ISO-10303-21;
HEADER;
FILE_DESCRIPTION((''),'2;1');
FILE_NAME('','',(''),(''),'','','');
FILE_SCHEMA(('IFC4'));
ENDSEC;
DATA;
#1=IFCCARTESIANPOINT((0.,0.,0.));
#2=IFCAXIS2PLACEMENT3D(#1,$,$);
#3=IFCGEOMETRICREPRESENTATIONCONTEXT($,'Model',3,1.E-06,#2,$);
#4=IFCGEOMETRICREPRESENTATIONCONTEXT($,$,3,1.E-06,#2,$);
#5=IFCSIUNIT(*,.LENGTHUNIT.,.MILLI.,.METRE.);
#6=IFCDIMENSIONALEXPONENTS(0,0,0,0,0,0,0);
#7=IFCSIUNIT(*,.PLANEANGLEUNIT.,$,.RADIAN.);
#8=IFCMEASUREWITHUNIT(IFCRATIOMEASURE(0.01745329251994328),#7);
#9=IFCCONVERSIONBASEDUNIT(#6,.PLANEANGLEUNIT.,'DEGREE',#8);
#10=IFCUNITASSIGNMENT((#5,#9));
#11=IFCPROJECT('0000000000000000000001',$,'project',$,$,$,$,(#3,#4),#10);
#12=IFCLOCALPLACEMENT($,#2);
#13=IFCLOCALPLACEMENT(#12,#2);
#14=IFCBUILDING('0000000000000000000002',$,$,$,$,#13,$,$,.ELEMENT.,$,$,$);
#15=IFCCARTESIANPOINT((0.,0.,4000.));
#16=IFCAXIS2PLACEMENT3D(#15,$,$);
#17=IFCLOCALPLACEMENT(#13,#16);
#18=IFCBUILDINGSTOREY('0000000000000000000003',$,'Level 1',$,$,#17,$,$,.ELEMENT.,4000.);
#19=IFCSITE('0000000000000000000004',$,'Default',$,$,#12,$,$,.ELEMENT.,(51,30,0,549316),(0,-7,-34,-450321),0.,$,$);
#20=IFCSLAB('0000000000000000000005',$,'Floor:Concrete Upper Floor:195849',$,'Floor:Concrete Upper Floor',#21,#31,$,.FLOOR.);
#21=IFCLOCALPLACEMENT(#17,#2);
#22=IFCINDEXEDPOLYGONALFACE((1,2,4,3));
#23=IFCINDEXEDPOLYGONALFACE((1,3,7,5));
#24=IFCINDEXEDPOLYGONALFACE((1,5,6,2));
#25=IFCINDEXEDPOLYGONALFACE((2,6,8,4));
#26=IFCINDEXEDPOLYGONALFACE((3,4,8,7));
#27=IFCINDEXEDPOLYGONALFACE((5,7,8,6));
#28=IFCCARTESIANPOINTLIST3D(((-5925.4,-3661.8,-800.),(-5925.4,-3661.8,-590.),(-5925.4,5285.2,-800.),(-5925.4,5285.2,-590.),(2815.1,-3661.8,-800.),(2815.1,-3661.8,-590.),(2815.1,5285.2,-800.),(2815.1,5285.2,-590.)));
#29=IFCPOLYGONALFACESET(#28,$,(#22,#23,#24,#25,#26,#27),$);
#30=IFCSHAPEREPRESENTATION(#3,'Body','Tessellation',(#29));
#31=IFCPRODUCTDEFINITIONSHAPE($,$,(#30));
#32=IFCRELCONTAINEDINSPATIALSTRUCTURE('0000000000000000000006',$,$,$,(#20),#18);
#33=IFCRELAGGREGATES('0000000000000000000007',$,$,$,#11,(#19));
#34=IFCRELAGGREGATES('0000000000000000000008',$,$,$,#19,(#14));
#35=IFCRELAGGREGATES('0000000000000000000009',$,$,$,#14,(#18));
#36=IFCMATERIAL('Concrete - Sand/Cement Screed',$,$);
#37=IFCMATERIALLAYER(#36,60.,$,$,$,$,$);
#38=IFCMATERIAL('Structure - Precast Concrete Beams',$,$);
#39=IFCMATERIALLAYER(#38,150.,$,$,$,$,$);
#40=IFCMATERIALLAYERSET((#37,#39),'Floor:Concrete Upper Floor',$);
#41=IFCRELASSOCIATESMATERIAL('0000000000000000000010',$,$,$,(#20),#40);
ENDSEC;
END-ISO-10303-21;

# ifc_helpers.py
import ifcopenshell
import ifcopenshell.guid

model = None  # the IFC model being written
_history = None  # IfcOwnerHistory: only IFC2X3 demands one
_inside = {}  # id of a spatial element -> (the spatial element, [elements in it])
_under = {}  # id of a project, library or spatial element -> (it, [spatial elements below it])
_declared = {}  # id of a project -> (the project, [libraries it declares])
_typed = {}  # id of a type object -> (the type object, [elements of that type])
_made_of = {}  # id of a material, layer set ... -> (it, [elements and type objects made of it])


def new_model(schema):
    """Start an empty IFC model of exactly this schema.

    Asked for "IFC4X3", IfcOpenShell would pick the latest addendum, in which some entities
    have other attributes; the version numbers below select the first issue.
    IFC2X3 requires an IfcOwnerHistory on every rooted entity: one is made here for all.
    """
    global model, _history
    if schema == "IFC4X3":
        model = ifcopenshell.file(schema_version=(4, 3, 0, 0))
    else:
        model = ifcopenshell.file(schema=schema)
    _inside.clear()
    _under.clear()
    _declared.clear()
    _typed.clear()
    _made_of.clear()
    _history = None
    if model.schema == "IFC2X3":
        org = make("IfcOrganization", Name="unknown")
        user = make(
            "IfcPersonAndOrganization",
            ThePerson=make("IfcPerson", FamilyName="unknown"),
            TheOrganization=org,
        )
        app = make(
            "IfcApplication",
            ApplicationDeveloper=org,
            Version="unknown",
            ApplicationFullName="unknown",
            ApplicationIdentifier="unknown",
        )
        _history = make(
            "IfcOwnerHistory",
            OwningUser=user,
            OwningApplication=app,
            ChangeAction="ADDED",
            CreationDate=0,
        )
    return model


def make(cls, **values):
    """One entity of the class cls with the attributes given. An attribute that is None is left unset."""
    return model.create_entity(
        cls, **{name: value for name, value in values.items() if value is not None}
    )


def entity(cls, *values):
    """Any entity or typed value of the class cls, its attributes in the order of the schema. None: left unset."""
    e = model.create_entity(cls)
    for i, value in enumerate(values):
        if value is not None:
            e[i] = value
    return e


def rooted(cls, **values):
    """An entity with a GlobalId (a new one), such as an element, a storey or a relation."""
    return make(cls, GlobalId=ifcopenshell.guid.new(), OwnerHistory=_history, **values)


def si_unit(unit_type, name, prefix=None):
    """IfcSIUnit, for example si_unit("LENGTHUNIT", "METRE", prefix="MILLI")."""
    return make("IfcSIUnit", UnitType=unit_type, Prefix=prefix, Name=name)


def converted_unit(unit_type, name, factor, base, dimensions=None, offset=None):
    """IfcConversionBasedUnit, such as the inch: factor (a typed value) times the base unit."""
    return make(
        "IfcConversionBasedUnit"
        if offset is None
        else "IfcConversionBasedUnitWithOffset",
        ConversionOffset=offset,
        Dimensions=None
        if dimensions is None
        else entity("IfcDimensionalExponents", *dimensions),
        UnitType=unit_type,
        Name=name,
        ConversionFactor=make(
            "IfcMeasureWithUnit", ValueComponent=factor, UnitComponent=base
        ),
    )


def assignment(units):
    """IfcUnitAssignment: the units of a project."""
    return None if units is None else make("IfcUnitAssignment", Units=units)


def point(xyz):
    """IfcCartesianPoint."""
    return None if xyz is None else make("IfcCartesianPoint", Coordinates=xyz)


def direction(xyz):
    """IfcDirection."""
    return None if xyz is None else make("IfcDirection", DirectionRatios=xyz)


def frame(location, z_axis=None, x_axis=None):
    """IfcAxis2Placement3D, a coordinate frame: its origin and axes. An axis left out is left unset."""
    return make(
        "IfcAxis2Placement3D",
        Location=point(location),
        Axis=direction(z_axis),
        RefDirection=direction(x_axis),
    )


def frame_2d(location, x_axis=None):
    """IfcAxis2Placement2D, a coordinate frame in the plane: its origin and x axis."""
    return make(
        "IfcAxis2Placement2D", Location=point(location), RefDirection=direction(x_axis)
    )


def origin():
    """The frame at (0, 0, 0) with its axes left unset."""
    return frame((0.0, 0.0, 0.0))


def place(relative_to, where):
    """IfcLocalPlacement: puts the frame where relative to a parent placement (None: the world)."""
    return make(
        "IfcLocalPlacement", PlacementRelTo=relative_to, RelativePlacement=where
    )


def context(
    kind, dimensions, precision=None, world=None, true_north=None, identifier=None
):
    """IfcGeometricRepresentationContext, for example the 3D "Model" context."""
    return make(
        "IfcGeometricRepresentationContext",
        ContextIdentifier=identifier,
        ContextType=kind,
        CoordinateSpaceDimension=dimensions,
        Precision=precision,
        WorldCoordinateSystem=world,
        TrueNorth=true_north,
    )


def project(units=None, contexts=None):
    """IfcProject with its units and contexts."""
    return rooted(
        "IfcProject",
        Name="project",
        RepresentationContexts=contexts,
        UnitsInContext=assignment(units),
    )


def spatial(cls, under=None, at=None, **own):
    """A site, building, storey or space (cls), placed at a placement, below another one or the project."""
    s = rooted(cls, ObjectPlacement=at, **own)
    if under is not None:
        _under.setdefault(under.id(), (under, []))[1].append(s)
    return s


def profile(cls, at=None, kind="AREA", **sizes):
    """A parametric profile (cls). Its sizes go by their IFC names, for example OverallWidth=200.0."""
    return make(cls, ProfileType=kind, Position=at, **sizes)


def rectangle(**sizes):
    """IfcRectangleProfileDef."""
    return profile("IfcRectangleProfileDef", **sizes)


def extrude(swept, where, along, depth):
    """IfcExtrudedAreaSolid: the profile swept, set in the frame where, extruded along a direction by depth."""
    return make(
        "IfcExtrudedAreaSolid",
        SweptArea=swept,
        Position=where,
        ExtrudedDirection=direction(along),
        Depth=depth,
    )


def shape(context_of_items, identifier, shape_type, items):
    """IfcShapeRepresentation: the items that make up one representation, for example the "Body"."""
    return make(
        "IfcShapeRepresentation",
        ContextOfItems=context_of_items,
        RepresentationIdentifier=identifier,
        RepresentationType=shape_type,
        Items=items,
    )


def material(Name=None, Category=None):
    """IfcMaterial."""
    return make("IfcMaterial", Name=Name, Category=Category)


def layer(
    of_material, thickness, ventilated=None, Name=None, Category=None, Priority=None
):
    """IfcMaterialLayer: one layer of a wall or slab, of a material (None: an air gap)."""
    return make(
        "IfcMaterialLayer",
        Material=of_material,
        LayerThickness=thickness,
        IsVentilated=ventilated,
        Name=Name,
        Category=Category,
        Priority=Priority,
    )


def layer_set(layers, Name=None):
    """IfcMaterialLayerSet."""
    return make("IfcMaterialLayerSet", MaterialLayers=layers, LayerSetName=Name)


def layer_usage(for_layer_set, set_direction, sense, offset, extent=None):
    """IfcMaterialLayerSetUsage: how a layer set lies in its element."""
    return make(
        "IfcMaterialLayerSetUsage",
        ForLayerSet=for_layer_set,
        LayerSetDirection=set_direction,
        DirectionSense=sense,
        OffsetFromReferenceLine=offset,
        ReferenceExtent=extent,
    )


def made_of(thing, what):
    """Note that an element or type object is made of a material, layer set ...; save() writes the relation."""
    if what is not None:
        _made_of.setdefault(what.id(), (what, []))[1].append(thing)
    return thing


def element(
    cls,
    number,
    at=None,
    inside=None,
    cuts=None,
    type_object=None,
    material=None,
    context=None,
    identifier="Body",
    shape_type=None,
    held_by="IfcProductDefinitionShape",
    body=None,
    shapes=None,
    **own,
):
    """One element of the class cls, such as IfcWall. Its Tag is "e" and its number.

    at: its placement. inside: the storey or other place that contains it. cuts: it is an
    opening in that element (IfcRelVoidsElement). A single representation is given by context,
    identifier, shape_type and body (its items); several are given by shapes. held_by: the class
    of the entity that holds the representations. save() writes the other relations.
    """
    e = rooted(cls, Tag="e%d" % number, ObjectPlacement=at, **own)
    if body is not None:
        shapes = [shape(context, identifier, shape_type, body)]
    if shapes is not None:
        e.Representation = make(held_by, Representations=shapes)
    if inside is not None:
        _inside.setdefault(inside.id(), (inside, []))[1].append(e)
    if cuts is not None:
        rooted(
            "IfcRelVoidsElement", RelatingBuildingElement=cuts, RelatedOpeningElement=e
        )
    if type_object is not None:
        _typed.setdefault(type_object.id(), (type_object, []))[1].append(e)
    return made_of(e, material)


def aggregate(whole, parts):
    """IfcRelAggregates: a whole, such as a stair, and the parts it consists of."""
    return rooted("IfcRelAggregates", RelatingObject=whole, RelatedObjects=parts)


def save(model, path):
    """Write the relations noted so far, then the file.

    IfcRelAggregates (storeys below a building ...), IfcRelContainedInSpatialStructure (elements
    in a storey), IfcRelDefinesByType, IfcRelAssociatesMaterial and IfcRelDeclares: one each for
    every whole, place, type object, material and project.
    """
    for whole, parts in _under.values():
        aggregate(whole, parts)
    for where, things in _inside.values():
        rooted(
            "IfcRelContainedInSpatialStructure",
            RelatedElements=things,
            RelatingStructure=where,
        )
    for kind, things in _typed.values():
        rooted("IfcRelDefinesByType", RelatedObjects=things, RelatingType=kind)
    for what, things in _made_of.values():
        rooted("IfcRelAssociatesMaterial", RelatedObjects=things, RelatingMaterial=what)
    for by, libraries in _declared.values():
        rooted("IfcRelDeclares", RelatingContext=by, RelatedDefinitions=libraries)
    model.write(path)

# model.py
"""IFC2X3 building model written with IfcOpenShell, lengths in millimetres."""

from ifc_helpers import new_model, entity, si_unit, converted_unit, frame, frame_2d, origin, place, context, project, spatial, rectangle, extrude, material, layer, layer_set, layer_usage, element, save


model = new_model("IFC2X3")

# Units and contexts
model_context = context("Model", 3, precision=1e-06, world=origin())
context_of_model = context(None, 3, precision=1e-06, world=origin())
ifc_project = project(units=[si_unit("LENGTHUNIT", "METRE", prefix="MILLI"), converted_unit("PLANEANGLEUNIT", "DEGREE", entity("IfcRatioMeasure", 0.01745329251994328), si_unit("PLANEANGLEUNIT", "RADIAN"), dimensions=[0, 0, 0, 0, 0, 0, 0])], contexts=[model_context, context_of_model])

# Site, building, storey
site_placement = place(None, origin())
site = spatial("IfcSite", under=ifc_project, at=site_placement, Name="Default", CompositionType="ELEMENT", RefLatitude=(51, 30, 0, 549316), RefLongitude=(0, -7, -34, -450321), RefElevation=0.0)
building_placement = place(site_placement, origin())
building = spatial("IfcBuilding", under=site, at=building_placement, CompositionType="ELEMENT")
storey_placement = place(building_placement, frame((0.0, 0.0, 4000.0)))
storey = spatial("IfcBuildingStorey", under=building, at=storey_placement, Name="Level 1", CompositionType="ELEMENT", Elevation=4000.0)

# Slab
ifc_material_1 = material(Name="Concrete - Sand/Cement Screed")
ifc_layer_1 = layer(ifc_material_1, 60.0)
ifc_material_2 = material(Name="Structure - Precast Concrete Beams")
ifc_layer_2 = layer(ifc_material_2, 150.0)
ifc_layer_set = layer_set([ifc_layer_1, ifc_layer_2], Name="Floor:Concrete Upper Floor")
ifc_layer_usage = layer_usage(ifc_layer_set, "AXIS3", "POSITIVE", 0.0)
slab_placement = place(storey_placement, frame((-5925.4, -3661.8, -800.0)))
element("IfcSlab", 1, at=slab_placement, inside=storey, material=ifc_layer_usage, Name="Floor:Concrete Upper Floor:195849", ObjectType="Floor:Concrete Upper Floor", PredefinedType="FLOOR", context=model_context, shape_type="SweptSolid", body=[
    extrude(rectangle(XDim=8947.0, YDim=8740.5, at=frame_2d((0.0, 0.0), x_axis=(0.0, -1.0))), frame((4370.3, 4473.5, 210.0), z_axis=(0.0, 0.0, -1.0), x_axis=(-1.0, 0.0, 0.0)), (0.0, 0.0, 1.0), 210.0),
])

save(model, "model.ifc")
